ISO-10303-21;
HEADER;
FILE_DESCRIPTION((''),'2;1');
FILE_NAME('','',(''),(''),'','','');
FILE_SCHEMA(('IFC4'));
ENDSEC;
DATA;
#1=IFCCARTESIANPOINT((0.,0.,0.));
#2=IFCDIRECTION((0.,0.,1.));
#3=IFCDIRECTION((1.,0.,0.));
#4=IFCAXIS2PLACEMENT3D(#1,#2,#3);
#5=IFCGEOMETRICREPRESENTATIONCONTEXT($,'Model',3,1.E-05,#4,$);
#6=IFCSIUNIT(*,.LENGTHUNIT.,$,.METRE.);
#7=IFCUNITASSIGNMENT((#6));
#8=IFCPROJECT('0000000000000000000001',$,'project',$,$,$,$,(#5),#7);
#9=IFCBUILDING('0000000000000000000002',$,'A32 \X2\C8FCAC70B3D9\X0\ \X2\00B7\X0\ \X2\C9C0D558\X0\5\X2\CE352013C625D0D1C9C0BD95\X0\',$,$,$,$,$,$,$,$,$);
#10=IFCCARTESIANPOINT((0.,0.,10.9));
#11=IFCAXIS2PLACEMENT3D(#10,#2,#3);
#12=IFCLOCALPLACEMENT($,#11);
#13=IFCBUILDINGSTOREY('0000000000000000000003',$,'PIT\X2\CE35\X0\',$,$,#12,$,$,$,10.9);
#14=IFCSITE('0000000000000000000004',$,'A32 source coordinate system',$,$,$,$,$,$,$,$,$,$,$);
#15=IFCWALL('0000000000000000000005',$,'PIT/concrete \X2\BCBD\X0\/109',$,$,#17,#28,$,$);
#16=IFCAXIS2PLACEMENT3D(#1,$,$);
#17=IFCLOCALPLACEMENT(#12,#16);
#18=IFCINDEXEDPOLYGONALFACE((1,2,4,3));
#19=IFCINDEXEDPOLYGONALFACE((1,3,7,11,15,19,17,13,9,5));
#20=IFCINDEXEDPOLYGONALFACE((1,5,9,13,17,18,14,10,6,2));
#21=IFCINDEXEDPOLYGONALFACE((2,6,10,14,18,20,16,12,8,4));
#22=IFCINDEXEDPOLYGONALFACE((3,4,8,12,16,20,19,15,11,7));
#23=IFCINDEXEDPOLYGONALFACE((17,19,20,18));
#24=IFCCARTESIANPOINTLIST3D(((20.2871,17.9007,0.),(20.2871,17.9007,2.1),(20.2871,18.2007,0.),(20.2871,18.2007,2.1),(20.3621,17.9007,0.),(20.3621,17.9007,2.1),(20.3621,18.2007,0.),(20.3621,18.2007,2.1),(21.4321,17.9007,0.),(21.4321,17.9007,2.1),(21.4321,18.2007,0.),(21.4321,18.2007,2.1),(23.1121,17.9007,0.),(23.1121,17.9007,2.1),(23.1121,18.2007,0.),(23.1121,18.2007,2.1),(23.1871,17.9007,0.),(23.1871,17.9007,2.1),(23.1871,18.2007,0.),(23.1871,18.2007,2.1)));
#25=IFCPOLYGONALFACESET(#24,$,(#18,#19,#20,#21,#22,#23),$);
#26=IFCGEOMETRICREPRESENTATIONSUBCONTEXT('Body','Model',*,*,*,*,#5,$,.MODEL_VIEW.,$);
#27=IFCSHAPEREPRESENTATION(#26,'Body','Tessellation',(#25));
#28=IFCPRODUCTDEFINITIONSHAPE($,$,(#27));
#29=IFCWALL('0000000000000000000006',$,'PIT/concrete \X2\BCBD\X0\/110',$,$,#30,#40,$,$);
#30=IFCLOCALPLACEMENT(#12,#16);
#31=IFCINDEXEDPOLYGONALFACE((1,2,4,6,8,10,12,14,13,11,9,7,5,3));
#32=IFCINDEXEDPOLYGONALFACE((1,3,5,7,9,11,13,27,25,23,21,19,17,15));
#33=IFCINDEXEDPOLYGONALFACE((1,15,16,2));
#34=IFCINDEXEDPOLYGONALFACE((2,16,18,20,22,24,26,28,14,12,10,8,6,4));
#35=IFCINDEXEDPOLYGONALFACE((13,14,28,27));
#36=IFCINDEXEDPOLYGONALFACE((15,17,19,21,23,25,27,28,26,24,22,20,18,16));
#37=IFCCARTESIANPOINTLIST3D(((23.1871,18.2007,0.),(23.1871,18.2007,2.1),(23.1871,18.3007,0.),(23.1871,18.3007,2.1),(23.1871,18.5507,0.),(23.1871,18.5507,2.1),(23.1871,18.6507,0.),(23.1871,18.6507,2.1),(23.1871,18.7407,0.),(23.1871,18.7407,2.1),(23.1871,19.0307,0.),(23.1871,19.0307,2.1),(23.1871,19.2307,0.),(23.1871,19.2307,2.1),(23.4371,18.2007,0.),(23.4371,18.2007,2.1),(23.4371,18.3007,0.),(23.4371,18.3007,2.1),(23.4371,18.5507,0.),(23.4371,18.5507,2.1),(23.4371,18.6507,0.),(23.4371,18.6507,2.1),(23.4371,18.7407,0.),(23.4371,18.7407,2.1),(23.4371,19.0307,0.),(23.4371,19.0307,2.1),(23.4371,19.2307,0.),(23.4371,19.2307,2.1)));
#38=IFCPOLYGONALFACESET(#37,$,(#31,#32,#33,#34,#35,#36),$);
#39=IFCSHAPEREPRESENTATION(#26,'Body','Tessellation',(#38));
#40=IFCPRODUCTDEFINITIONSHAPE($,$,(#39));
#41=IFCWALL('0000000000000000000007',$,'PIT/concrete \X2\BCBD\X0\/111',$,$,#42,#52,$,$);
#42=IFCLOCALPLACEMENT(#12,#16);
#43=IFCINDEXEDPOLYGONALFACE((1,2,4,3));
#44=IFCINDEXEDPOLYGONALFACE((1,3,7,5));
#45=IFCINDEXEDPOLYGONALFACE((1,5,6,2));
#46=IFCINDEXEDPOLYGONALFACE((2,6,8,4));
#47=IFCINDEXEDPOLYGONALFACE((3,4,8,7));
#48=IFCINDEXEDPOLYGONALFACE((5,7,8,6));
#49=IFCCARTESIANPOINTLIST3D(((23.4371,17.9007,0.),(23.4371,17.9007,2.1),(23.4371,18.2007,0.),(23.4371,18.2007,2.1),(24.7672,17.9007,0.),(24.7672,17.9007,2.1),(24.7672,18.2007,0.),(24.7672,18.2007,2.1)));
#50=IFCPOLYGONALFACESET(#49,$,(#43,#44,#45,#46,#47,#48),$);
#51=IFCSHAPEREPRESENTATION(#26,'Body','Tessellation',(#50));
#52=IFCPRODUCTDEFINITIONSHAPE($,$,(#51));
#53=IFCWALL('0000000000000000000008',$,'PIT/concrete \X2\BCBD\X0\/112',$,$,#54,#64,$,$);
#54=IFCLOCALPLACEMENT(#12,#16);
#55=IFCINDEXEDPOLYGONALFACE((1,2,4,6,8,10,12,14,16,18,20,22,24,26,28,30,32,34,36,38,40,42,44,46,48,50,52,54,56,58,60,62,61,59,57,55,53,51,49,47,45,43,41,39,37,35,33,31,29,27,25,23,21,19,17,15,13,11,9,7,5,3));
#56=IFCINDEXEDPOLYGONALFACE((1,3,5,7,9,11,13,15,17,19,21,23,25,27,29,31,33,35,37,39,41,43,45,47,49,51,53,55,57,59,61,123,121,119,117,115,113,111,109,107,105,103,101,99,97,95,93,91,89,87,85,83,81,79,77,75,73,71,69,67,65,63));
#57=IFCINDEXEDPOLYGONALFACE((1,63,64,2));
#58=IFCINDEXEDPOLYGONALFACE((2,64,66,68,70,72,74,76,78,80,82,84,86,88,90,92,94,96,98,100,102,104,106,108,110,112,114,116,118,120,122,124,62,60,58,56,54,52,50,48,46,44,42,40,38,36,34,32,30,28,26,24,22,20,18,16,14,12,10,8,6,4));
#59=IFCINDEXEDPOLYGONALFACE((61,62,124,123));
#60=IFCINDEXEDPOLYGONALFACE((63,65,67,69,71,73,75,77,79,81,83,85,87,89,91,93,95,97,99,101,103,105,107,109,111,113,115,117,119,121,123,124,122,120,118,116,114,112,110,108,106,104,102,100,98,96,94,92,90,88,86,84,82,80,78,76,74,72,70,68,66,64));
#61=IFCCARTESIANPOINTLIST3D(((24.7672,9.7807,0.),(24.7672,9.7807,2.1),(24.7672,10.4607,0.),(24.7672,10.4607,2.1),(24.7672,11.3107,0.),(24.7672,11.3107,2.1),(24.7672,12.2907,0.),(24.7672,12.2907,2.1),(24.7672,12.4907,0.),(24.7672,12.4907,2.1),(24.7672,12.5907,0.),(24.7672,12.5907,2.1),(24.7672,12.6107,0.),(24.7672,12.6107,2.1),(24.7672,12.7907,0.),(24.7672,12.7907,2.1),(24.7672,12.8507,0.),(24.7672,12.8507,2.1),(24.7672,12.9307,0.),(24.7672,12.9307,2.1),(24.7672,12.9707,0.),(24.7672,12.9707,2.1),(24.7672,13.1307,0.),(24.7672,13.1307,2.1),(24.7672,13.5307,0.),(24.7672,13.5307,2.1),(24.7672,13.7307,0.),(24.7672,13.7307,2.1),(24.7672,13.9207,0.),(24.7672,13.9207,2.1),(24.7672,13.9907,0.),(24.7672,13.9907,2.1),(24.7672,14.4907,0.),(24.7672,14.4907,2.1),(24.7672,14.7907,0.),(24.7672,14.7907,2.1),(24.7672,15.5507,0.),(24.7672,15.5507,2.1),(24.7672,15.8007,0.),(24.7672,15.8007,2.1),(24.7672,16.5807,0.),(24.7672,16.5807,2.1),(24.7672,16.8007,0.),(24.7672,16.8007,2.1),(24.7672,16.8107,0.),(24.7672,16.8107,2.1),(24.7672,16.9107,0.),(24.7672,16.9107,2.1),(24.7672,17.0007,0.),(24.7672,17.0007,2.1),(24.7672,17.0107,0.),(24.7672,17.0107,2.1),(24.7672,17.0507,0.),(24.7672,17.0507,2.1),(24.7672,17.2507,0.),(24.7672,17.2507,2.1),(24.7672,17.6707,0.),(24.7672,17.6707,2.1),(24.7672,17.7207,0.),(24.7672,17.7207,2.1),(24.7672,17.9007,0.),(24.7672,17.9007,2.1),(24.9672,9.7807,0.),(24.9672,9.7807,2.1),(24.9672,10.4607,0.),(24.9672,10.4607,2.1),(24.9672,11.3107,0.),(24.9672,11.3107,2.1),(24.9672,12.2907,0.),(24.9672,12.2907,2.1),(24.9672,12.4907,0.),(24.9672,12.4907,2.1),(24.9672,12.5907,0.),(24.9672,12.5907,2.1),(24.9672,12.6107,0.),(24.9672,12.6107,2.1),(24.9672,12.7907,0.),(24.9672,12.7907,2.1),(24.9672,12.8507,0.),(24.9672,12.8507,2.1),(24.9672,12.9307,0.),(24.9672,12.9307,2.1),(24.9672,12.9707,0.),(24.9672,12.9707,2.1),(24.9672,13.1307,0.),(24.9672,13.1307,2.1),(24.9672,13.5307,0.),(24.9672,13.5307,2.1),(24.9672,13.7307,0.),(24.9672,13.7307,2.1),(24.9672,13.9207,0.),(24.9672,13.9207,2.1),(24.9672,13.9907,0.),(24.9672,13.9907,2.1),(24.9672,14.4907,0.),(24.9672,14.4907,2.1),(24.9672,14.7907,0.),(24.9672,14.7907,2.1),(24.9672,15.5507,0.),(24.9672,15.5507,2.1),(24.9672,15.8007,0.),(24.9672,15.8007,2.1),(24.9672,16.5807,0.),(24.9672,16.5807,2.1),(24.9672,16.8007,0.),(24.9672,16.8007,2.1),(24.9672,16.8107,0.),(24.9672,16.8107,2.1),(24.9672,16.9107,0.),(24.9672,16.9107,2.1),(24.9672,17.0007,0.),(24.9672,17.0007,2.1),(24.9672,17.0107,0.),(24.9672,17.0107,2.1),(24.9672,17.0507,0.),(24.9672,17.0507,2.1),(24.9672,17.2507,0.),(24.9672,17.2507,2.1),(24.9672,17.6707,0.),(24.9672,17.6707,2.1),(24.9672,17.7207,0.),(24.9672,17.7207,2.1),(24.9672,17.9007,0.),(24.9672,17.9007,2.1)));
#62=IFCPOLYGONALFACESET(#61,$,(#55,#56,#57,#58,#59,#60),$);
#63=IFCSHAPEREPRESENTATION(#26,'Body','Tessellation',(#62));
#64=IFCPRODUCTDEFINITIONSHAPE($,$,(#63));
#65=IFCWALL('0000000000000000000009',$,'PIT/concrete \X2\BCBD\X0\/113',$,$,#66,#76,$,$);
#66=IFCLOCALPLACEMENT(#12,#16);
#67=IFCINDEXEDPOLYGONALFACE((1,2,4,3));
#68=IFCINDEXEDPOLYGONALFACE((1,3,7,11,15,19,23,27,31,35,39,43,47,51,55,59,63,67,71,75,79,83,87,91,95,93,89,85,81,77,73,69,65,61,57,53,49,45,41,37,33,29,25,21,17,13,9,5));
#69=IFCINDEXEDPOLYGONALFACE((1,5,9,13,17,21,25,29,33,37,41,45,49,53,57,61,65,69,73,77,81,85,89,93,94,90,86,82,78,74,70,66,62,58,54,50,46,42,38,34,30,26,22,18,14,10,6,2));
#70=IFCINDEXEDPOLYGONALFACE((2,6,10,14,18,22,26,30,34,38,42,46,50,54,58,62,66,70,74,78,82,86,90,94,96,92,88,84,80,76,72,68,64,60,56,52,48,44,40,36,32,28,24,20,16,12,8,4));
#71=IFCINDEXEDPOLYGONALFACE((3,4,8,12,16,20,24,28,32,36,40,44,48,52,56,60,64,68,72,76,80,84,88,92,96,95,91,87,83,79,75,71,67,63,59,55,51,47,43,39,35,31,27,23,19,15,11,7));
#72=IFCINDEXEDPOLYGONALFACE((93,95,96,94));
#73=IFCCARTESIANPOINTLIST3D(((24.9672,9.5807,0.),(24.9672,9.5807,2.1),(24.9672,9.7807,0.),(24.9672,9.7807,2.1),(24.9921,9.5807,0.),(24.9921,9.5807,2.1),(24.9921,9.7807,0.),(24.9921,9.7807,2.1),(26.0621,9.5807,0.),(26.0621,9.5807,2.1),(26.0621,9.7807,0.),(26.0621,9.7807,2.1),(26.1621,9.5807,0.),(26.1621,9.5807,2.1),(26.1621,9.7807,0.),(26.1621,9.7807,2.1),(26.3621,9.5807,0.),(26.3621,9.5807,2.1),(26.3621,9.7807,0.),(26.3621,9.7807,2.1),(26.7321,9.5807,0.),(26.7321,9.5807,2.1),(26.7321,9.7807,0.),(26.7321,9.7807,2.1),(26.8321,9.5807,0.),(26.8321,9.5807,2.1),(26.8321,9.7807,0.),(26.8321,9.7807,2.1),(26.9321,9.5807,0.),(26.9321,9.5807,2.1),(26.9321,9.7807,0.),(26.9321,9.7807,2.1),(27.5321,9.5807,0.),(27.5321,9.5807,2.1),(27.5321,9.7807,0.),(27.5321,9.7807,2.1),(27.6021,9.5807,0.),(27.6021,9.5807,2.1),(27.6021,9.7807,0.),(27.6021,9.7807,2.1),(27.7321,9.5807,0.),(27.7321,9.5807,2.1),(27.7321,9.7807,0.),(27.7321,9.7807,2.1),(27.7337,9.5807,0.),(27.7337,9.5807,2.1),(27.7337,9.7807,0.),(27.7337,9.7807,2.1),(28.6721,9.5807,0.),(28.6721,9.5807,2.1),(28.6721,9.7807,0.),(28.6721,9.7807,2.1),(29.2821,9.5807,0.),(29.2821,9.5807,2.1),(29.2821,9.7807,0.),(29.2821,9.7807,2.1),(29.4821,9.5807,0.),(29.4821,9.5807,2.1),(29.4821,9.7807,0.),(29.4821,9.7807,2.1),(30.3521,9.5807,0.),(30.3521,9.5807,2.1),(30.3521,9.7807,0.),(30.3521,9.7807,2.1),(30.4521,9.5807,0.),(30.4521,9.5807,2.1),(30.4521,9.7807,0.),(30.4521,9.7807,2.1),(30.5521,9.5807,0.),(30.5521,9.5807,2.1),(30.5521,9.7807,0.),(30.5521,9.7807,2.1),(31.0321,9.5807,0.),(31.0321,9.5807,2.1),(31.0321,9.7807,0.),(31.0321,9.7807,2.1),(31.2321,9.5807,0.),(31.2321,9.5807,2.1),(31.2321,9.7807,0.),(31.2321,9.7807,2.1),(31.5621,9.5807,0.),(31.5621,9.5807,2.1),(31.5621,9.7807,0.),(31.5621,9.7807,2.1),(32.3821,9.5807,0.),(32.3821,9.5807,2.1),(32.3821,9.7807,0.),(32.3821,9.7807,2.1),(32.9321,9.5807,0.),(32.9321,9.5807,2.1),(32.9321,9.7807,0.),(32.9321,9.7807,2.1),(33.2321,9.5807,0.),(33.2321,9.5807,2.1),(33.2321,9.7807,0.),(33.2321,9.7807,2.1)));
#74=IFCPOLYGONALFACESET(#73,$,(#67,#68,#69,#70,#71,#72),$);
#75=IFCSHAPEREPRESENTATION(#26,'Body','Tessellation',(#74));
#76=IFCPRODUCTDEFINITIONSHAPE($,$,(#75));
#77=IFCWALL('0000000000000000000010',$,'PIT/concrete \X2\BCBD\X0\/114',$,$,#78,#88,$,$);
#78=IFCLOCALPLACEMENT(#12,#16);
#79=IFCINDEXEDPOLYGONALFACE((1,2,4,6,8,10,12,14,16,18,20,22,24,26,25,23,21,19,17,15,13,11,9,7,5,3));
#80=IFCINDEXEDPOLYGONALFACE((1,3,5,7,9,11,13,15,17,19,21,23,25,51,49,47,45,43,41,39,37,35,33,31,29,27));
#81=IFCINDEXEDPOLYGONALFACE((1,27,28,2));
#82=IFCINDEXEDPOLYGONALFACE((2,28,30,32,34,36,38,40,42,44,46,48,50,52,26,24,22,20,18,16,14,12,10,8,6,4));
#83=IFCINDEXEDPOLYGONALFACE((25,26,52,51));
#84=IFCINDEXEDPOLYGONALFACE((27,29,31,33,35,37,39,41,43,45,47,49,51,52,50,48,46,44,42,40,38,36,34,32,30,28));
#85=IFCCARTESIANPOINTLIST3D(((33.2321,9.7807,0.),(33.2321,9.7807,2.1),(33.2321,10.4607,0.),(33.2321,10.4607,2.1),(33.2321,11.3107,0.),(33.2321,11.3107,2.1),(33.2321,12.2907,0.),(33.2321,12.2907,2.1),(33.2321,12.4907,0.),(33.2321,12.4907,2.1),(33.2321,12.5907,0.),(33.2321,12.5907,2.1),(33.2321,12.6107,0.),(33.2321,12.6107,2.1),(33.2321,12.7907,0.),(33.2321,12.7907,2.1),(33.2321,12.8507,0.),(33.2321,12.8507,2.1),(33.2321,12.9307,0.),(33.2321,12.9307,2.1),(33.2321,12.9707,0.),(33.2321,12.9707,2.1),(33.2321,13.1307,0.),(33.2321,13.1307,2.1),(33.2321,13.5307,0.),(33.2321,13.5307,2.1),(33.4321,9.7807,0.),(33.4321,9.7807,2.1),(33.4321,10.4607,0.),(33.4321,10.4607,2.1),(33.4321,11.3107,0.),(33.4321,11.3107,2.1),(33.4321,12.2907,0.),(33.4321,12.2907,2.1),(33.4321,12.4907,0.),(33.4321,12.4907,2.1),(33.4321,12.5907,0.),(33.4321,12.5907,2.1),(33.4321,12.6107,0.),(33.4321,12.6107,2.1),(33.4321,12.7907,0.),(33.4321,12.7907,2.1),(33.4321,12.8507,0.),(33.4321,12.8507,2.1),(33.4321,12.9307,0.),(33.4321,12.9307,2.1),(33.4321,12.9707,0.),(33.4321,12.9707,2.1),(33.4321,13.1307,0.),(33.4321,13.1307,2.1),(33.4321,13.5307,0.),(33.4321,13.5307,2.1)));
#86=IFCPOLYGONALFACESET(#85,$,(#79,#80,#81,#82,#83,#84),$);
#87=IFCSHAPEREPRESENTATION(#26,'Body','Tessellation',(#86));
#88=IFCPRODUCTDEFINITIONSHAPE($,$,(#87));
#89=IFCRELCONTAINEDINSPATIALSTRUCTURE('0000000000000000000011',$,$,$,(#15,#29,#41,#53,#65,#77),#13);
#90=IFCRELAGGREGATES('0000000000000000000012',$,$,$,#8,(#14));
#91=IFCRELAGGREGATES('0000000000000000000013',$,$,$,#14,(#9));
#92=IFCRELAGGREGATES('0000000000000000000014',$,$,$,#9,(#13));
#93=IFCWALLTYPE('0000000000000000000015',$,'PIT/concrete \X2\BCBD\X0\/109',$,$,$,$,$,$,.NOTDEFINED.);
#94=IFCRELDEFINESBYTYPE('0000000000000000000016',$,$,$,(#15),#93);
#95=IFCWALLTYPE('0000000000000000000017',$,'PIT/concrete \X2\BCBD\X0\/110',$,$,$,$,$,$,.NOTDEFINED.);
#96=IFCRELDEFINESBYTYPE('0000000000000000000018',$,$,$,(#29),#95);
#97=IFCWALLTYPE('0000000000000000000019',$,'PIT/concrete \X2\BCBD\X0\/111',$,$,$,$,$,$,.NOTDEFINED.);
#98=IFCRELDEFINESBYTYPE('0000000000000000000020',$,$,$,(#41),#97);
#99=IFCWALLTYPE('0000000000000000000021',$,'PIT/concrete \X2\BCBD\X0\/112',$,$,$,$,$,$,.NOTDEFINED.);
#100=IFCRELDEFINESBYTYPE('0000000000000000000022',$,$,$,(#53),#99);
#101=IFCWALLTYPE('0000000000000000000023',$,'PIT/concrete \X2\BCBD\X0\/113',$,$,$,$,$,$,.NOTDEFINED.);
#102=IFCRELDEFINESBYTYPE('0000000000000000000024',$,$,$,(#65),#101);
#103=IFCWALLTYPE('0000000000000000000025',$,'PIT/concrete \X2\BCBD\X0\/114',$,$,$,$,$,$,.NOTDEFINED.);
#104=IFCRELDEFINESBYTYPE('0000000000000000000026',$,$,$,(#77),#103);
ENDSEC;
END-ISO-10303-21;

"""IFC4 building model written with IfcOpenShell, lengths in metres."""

from ifc_helpers import new_model, si_unit, frame, origin, origin_with_axes, place, context, subcontext, project, spatial, polyline, outline, extrude, source, transform, mapped, type_object, type_shapes, element, save


model = new_model("IFC4")

# Units and contexts
model_context = context("Model", 3, precision=1e-05, world=origin_with_axes())
body_context = subcontext(model_context, "Body", "Model", "MODEL_VIEW")
ifc_project = project(units=[si_unit("LENGTHUNIT", "METRE")], contexts=[model_context])

# Site, building, storey
site = spatial("IfcSite", under=ifc_project, Name="A32 source coordinate system")
building = spatial("IfcBuilding", under=site, Name="A32 주거동 · 지하5층–옥탑지붕")
storey_placement = place(None, frame((0.0, 0.0, 10.9), z_axis=(0.0, 0.0, 1.0), x_axis=(1.0, 0.0, 0.0)))
storey = spatial("IfcBuildingStorey", under=building, at=storey_placement, Name="PIT층", Elevation=10.9)

# Walls
wall_type_1 = type_object("IfcWallType", Name="PIT/concrete 벽/109", PredefinedType="NOTDEFINED")
shared_shape_1 = source(origin(), body_context, "Body", "SweptSolid", [
    extrude(outline(polyline([(23.1121, 18.2007), (23.1871, 18.2007), (23.1871, 17.9007), (23.1121, 17.9007), (21.4321, 17.9007), (20.3621, 17.9007), (20.2871, 17.9007), (20.2871, 18.2007), (20.3621, 18.2007), (21.4321, 18.2007), (23.1121, 18.2007)])), origin(), (0.0, 0.0, 1.0), 2.1),
])
type_shapes(wall_type_1, [shared_shape_1])
wall_1_placement = place(storey_placement, origin_with_axes())
element("IfcWall", 1, at=wall_1_placement, inside=storey, type_object=wall_type_1, Name="PIT/concrete 벽/109", context=body_context, shape_type="MappedRepresentation", body=[
    mapped(shared_shape_1, transform((0.0, 0.0, 0.0), scale=1.0)),
])
wall_type_2 = type_object("IfcWallType", Name="PIT/concrete 벽/110", PredefinedType="NOTDEFINED")
shared_shape_2 = source(origin(), body_context, "Body", "SweptSolid", [
    extrude(outline(polyline([(23.1871, 18.6507), (23.1871, 18.7407), (23.1871, 19.0307), (23.1871, 19.2307), (23.4371, 19.2307), (23.4371, 19.0307), (23.4371, 18.7407), (23.4371, 18.6507), (23.4371, 18.5507), (23.4371, 18.3007), (23.4371, 18.2007), (23.1871, 18.2007), (23.1871, 18.3007), (23.1871, 18.5507), (23.1871, 18.6507)])), origin(), (0.0, 0.0, 1.0), 2.1),
])
type_shapes(wall_type_2, [shared_shape_2])
wall_2_placement = place(storey_placement, origin_with_axes())
element("IfcWall", 2, at=wall_2_placement, inside=storey, type_object=wall_type_2, Name="PIT/concrete 벽/110", context=body_context, shape_type="MappedRepresentation", body=[
    mapped(shared_shape_2, transform((0.0, 0.0, 0.0), scale=1.0)),
])
wall_type_3 = type_object("IfcWallType", Name="PIT/concrete 벽/111", PredefinedType="NOTDEFINED")
shared_shape_3 = source(origin(), body_context, "Body", "SweptSolid", [
    extrude(outline(polyline([(23.4371, 17.9007), (23.4371, 18.2007), (24.7672, 18.2007), (24.7672, 17.9007), (23.4371, 17.9007)])), origin(), (0.0, 0.0, 1.0), 2.1),
])
type_shapes(wall_type_3, [shared_shape_3])
wall_3_placement = place(storey_placement, origin_with_axes())
element("IfcWall", 3, at=wall_3_placement, inside=storey, type_object=wall_type_3, Name="PIT/concrete 벽/111", context=body_context, shape_type="MappedRepresentation", body=[
    mapped(shared_shape_3, transform((0.0, 0.0, 0.0), scale=1.0)),
])
wall_type_4 = type_object("IfcWallType", Name="PIT/concrete 벽/112", PredefinedType="NOTDEFINED")
shared_shape_4 = source(origin(), body_context, "Body", "SweptSolid", [
    extrude(outline(polyline([(24.9672, 17.6707), (24.9672, 17.2507), (24.9672, 17.0507), (24.9672, 17.0107), (24.9672, 17.0007), (24.9672, 16.9107), (24.9672, 16.8107), (24.9672, 16.8007), (24.9672, 16.5807), (24.9672, 15.8007), (24.9672, 15.5507), (24.9672, 14.7907), (24.9672, 14.4907), (24.9672, 13.9907), (24.9672, 13.9207), (24.9672, 13.7307), (24.9672, 13.5307), (24.9672, 13.1307), (24.9672, 12.9707), (24.9672, 12.9307), (24.9672, 12.8507), (24.9672, 12.7907), (24.9672, 12.6107), (24.9672, 12.5907), (24.9672, 12.4907), (24.9672, 12.2907), (24.9672, 11.3107), (24.9672, 10.4607), (24.9672, 9.7807), (24.7672, 9.7807), (24.7672, 10.4607), (24.7672, 11.3107), (24.7672, 12.2907), (24.7672, 12.4907), (24.7672, 12.5907), (24.7672, 12.6107), (24.7672, 12.7907), (24.7672, 12.8507), (24.7672, 12.9307), (24.7672, 12.9707), (24.7672, 13.1307), (24.7672, 13.5307), (24.7672, 13.7307), (24.7672, 13.9207), (24.7672, 13.9907), (24.7672, 14.4907), (24.7672, 14.7907), (24.7672, 15.5507), (24.7672, 15.8007), (24.7672, 16.5807), (24.7672, 16.8007), (24.7672, 16.8107), (24.7672, 16.9107), (24.7672, 17.0007), (24.7672, 17.0107), (24.7672, 17.0507), (24.7672, 17.2507), (24.7672, 17.6707), (24.7672, 17.7207), (24.7672, 17.9007), (24.9672, 17.9007), (24.9672, 17.7207), (24.9672, 17.6707)])), origin(), (0.0, 0.0, 1.0), 2.1),
])
type_shapes(wall_type_4, [shared_shape_4])
wall_4_placement = place(storey_placement, origin_with_axes())
element("IfcWall", 4, at=wall_4_placement, inside=storey, type_object=wall_type_4, Name="PIT/concrete 벽/112", context=body_context, shape_type="MappedRepresentation", body=[
    mapped(shared_shape_4, transform((0.0, 0.0, 0.0), scale=1.0)),
])
wall_type_5 = type_object("IfcWallType", Name="PIT/concrete 벽/113", PredefinedType="NOTDEFINED")
shared_shape_5 = source(origin(), body_context, "Body", "SweptSolid", [
    extrude(outline(polyline([(26.1621, 9.7807), (26.3621, 9.7807), (26.7321, 9.7807), (26.8321, 9.7807), (26.9321, 9.7807), (27.5321, 9.7807), (27.6021, 9.7807), (27.7321, 9.7807), (27.7337, 9.7807), (28.6721, 9.7807), (29.2821, 9.7807), (29.4821, 9.7807), (30.3521, 9.7807), (30.4521, 9.7807), (30.5521, 9.7807), (31.0321, 9.7807), (31.2321, 9.7807), (31.5621, 9.7807), (32.3821, 9.7807), (32.9321, 9.7807), (33.2321, 9.7807), (33.2321, 9.5807), (32.9321, 9.5807), (32.3821, 9.5807), (31.5621, 9.5807), (31.2321, 9.5807), (31.0321, 9.5807), (30.5521, 9.5807), (30.4521, 9.5807), (30.3521, 9.5807), (29.4821, 9.5807), (29.2821, 9.5807), (28.6721, 9.5807), (27.7337, 9.5807), (27.7321, 9.5807), (27.6021, 9.5807), (27.5321, 9.5807), (26.9321, 9.5807), (26.8321, 9.5807), (26.7321, 9.5807), (26.3621, 9.5807), (26.1621, 9.5807), (26.0621, 9.5807), (24.9921, 9.5807), (24.9672, 9.5807), (24.9672, 9.7807), (24.9921, 9.7807), (26.0621, 9.7807), (26.1621, 9.7807)])), origin(), (0.0, 0.0, 1.0), 2.1),
])
type_shapes(wall_type_5, [shared_shape_5])
wall_5_placement = place(storey_placement, origin_with_axes())
element("IfcWall", 5, at=wall_5_placement, inside=storey, type_object=wall_type_5, Name="PIT/concrete 벽/113", context=body_context, shape_type="MappedRepresentation", body=[
    mapped(shared_shape_5, transform((0.0, 0.0, 0.0), scale=1.0)),
])
wall_type_6 = type_object("IfcWallType", Name="PIT/concrete 벽/114", PredefinedType="NOTDEFINED")
shared_shape_6 = source(origin(), body_context, "Body", "SweptSolid", [
    extrude(outline(polyline([(33.2321, 12.2907), (33.2321, 12.4907), (33.2321, 12.5907), (33.2321, 12.6107), (33.2321, 12.7907), (33.2321, 12.8507), (33.2321, 12.9307), (33.2321, 12.9707), (33.2321, 13.1307), (33.2321, 13.5307), (33.4321, 13.5307), (33.4321, 13.1307), (33.4321, 12.9707), (33.4321, 12.9307), (33.4321, 12.8507), (33.4321, 12.7907), (33.4321, 12.6107), (33.4321, 12.5907), (33.4321, 12.4907), (33.4321, 12.2907), (33.4321, 11.3107), (33.4321, 10.4607), (33.4321, 9.7807), (33.2321, 9.7807), (33.2321, 10.4607), (33.2321, 11.3107), (33.2321, 12.2907)])), origin(), (0.0, 0.0, 1.0), 2.1),
])
type_shapes(wall_type_6, [shared_shape_6])
wall_6_placement = place(storey_placement, origin_with_axes())
element("IfcWall", 6, at=wall_6_placement, inside=storey, type_object=wall_type_6, Name="PIT/concrete 벽/114", context=body_context, shape_type="MappedRepresentation", body=[
    mapped(shared_shape_6, transform((0.0, 0.0, 0.0), scale=1.0)),
])

save(model, "model.ifc")
